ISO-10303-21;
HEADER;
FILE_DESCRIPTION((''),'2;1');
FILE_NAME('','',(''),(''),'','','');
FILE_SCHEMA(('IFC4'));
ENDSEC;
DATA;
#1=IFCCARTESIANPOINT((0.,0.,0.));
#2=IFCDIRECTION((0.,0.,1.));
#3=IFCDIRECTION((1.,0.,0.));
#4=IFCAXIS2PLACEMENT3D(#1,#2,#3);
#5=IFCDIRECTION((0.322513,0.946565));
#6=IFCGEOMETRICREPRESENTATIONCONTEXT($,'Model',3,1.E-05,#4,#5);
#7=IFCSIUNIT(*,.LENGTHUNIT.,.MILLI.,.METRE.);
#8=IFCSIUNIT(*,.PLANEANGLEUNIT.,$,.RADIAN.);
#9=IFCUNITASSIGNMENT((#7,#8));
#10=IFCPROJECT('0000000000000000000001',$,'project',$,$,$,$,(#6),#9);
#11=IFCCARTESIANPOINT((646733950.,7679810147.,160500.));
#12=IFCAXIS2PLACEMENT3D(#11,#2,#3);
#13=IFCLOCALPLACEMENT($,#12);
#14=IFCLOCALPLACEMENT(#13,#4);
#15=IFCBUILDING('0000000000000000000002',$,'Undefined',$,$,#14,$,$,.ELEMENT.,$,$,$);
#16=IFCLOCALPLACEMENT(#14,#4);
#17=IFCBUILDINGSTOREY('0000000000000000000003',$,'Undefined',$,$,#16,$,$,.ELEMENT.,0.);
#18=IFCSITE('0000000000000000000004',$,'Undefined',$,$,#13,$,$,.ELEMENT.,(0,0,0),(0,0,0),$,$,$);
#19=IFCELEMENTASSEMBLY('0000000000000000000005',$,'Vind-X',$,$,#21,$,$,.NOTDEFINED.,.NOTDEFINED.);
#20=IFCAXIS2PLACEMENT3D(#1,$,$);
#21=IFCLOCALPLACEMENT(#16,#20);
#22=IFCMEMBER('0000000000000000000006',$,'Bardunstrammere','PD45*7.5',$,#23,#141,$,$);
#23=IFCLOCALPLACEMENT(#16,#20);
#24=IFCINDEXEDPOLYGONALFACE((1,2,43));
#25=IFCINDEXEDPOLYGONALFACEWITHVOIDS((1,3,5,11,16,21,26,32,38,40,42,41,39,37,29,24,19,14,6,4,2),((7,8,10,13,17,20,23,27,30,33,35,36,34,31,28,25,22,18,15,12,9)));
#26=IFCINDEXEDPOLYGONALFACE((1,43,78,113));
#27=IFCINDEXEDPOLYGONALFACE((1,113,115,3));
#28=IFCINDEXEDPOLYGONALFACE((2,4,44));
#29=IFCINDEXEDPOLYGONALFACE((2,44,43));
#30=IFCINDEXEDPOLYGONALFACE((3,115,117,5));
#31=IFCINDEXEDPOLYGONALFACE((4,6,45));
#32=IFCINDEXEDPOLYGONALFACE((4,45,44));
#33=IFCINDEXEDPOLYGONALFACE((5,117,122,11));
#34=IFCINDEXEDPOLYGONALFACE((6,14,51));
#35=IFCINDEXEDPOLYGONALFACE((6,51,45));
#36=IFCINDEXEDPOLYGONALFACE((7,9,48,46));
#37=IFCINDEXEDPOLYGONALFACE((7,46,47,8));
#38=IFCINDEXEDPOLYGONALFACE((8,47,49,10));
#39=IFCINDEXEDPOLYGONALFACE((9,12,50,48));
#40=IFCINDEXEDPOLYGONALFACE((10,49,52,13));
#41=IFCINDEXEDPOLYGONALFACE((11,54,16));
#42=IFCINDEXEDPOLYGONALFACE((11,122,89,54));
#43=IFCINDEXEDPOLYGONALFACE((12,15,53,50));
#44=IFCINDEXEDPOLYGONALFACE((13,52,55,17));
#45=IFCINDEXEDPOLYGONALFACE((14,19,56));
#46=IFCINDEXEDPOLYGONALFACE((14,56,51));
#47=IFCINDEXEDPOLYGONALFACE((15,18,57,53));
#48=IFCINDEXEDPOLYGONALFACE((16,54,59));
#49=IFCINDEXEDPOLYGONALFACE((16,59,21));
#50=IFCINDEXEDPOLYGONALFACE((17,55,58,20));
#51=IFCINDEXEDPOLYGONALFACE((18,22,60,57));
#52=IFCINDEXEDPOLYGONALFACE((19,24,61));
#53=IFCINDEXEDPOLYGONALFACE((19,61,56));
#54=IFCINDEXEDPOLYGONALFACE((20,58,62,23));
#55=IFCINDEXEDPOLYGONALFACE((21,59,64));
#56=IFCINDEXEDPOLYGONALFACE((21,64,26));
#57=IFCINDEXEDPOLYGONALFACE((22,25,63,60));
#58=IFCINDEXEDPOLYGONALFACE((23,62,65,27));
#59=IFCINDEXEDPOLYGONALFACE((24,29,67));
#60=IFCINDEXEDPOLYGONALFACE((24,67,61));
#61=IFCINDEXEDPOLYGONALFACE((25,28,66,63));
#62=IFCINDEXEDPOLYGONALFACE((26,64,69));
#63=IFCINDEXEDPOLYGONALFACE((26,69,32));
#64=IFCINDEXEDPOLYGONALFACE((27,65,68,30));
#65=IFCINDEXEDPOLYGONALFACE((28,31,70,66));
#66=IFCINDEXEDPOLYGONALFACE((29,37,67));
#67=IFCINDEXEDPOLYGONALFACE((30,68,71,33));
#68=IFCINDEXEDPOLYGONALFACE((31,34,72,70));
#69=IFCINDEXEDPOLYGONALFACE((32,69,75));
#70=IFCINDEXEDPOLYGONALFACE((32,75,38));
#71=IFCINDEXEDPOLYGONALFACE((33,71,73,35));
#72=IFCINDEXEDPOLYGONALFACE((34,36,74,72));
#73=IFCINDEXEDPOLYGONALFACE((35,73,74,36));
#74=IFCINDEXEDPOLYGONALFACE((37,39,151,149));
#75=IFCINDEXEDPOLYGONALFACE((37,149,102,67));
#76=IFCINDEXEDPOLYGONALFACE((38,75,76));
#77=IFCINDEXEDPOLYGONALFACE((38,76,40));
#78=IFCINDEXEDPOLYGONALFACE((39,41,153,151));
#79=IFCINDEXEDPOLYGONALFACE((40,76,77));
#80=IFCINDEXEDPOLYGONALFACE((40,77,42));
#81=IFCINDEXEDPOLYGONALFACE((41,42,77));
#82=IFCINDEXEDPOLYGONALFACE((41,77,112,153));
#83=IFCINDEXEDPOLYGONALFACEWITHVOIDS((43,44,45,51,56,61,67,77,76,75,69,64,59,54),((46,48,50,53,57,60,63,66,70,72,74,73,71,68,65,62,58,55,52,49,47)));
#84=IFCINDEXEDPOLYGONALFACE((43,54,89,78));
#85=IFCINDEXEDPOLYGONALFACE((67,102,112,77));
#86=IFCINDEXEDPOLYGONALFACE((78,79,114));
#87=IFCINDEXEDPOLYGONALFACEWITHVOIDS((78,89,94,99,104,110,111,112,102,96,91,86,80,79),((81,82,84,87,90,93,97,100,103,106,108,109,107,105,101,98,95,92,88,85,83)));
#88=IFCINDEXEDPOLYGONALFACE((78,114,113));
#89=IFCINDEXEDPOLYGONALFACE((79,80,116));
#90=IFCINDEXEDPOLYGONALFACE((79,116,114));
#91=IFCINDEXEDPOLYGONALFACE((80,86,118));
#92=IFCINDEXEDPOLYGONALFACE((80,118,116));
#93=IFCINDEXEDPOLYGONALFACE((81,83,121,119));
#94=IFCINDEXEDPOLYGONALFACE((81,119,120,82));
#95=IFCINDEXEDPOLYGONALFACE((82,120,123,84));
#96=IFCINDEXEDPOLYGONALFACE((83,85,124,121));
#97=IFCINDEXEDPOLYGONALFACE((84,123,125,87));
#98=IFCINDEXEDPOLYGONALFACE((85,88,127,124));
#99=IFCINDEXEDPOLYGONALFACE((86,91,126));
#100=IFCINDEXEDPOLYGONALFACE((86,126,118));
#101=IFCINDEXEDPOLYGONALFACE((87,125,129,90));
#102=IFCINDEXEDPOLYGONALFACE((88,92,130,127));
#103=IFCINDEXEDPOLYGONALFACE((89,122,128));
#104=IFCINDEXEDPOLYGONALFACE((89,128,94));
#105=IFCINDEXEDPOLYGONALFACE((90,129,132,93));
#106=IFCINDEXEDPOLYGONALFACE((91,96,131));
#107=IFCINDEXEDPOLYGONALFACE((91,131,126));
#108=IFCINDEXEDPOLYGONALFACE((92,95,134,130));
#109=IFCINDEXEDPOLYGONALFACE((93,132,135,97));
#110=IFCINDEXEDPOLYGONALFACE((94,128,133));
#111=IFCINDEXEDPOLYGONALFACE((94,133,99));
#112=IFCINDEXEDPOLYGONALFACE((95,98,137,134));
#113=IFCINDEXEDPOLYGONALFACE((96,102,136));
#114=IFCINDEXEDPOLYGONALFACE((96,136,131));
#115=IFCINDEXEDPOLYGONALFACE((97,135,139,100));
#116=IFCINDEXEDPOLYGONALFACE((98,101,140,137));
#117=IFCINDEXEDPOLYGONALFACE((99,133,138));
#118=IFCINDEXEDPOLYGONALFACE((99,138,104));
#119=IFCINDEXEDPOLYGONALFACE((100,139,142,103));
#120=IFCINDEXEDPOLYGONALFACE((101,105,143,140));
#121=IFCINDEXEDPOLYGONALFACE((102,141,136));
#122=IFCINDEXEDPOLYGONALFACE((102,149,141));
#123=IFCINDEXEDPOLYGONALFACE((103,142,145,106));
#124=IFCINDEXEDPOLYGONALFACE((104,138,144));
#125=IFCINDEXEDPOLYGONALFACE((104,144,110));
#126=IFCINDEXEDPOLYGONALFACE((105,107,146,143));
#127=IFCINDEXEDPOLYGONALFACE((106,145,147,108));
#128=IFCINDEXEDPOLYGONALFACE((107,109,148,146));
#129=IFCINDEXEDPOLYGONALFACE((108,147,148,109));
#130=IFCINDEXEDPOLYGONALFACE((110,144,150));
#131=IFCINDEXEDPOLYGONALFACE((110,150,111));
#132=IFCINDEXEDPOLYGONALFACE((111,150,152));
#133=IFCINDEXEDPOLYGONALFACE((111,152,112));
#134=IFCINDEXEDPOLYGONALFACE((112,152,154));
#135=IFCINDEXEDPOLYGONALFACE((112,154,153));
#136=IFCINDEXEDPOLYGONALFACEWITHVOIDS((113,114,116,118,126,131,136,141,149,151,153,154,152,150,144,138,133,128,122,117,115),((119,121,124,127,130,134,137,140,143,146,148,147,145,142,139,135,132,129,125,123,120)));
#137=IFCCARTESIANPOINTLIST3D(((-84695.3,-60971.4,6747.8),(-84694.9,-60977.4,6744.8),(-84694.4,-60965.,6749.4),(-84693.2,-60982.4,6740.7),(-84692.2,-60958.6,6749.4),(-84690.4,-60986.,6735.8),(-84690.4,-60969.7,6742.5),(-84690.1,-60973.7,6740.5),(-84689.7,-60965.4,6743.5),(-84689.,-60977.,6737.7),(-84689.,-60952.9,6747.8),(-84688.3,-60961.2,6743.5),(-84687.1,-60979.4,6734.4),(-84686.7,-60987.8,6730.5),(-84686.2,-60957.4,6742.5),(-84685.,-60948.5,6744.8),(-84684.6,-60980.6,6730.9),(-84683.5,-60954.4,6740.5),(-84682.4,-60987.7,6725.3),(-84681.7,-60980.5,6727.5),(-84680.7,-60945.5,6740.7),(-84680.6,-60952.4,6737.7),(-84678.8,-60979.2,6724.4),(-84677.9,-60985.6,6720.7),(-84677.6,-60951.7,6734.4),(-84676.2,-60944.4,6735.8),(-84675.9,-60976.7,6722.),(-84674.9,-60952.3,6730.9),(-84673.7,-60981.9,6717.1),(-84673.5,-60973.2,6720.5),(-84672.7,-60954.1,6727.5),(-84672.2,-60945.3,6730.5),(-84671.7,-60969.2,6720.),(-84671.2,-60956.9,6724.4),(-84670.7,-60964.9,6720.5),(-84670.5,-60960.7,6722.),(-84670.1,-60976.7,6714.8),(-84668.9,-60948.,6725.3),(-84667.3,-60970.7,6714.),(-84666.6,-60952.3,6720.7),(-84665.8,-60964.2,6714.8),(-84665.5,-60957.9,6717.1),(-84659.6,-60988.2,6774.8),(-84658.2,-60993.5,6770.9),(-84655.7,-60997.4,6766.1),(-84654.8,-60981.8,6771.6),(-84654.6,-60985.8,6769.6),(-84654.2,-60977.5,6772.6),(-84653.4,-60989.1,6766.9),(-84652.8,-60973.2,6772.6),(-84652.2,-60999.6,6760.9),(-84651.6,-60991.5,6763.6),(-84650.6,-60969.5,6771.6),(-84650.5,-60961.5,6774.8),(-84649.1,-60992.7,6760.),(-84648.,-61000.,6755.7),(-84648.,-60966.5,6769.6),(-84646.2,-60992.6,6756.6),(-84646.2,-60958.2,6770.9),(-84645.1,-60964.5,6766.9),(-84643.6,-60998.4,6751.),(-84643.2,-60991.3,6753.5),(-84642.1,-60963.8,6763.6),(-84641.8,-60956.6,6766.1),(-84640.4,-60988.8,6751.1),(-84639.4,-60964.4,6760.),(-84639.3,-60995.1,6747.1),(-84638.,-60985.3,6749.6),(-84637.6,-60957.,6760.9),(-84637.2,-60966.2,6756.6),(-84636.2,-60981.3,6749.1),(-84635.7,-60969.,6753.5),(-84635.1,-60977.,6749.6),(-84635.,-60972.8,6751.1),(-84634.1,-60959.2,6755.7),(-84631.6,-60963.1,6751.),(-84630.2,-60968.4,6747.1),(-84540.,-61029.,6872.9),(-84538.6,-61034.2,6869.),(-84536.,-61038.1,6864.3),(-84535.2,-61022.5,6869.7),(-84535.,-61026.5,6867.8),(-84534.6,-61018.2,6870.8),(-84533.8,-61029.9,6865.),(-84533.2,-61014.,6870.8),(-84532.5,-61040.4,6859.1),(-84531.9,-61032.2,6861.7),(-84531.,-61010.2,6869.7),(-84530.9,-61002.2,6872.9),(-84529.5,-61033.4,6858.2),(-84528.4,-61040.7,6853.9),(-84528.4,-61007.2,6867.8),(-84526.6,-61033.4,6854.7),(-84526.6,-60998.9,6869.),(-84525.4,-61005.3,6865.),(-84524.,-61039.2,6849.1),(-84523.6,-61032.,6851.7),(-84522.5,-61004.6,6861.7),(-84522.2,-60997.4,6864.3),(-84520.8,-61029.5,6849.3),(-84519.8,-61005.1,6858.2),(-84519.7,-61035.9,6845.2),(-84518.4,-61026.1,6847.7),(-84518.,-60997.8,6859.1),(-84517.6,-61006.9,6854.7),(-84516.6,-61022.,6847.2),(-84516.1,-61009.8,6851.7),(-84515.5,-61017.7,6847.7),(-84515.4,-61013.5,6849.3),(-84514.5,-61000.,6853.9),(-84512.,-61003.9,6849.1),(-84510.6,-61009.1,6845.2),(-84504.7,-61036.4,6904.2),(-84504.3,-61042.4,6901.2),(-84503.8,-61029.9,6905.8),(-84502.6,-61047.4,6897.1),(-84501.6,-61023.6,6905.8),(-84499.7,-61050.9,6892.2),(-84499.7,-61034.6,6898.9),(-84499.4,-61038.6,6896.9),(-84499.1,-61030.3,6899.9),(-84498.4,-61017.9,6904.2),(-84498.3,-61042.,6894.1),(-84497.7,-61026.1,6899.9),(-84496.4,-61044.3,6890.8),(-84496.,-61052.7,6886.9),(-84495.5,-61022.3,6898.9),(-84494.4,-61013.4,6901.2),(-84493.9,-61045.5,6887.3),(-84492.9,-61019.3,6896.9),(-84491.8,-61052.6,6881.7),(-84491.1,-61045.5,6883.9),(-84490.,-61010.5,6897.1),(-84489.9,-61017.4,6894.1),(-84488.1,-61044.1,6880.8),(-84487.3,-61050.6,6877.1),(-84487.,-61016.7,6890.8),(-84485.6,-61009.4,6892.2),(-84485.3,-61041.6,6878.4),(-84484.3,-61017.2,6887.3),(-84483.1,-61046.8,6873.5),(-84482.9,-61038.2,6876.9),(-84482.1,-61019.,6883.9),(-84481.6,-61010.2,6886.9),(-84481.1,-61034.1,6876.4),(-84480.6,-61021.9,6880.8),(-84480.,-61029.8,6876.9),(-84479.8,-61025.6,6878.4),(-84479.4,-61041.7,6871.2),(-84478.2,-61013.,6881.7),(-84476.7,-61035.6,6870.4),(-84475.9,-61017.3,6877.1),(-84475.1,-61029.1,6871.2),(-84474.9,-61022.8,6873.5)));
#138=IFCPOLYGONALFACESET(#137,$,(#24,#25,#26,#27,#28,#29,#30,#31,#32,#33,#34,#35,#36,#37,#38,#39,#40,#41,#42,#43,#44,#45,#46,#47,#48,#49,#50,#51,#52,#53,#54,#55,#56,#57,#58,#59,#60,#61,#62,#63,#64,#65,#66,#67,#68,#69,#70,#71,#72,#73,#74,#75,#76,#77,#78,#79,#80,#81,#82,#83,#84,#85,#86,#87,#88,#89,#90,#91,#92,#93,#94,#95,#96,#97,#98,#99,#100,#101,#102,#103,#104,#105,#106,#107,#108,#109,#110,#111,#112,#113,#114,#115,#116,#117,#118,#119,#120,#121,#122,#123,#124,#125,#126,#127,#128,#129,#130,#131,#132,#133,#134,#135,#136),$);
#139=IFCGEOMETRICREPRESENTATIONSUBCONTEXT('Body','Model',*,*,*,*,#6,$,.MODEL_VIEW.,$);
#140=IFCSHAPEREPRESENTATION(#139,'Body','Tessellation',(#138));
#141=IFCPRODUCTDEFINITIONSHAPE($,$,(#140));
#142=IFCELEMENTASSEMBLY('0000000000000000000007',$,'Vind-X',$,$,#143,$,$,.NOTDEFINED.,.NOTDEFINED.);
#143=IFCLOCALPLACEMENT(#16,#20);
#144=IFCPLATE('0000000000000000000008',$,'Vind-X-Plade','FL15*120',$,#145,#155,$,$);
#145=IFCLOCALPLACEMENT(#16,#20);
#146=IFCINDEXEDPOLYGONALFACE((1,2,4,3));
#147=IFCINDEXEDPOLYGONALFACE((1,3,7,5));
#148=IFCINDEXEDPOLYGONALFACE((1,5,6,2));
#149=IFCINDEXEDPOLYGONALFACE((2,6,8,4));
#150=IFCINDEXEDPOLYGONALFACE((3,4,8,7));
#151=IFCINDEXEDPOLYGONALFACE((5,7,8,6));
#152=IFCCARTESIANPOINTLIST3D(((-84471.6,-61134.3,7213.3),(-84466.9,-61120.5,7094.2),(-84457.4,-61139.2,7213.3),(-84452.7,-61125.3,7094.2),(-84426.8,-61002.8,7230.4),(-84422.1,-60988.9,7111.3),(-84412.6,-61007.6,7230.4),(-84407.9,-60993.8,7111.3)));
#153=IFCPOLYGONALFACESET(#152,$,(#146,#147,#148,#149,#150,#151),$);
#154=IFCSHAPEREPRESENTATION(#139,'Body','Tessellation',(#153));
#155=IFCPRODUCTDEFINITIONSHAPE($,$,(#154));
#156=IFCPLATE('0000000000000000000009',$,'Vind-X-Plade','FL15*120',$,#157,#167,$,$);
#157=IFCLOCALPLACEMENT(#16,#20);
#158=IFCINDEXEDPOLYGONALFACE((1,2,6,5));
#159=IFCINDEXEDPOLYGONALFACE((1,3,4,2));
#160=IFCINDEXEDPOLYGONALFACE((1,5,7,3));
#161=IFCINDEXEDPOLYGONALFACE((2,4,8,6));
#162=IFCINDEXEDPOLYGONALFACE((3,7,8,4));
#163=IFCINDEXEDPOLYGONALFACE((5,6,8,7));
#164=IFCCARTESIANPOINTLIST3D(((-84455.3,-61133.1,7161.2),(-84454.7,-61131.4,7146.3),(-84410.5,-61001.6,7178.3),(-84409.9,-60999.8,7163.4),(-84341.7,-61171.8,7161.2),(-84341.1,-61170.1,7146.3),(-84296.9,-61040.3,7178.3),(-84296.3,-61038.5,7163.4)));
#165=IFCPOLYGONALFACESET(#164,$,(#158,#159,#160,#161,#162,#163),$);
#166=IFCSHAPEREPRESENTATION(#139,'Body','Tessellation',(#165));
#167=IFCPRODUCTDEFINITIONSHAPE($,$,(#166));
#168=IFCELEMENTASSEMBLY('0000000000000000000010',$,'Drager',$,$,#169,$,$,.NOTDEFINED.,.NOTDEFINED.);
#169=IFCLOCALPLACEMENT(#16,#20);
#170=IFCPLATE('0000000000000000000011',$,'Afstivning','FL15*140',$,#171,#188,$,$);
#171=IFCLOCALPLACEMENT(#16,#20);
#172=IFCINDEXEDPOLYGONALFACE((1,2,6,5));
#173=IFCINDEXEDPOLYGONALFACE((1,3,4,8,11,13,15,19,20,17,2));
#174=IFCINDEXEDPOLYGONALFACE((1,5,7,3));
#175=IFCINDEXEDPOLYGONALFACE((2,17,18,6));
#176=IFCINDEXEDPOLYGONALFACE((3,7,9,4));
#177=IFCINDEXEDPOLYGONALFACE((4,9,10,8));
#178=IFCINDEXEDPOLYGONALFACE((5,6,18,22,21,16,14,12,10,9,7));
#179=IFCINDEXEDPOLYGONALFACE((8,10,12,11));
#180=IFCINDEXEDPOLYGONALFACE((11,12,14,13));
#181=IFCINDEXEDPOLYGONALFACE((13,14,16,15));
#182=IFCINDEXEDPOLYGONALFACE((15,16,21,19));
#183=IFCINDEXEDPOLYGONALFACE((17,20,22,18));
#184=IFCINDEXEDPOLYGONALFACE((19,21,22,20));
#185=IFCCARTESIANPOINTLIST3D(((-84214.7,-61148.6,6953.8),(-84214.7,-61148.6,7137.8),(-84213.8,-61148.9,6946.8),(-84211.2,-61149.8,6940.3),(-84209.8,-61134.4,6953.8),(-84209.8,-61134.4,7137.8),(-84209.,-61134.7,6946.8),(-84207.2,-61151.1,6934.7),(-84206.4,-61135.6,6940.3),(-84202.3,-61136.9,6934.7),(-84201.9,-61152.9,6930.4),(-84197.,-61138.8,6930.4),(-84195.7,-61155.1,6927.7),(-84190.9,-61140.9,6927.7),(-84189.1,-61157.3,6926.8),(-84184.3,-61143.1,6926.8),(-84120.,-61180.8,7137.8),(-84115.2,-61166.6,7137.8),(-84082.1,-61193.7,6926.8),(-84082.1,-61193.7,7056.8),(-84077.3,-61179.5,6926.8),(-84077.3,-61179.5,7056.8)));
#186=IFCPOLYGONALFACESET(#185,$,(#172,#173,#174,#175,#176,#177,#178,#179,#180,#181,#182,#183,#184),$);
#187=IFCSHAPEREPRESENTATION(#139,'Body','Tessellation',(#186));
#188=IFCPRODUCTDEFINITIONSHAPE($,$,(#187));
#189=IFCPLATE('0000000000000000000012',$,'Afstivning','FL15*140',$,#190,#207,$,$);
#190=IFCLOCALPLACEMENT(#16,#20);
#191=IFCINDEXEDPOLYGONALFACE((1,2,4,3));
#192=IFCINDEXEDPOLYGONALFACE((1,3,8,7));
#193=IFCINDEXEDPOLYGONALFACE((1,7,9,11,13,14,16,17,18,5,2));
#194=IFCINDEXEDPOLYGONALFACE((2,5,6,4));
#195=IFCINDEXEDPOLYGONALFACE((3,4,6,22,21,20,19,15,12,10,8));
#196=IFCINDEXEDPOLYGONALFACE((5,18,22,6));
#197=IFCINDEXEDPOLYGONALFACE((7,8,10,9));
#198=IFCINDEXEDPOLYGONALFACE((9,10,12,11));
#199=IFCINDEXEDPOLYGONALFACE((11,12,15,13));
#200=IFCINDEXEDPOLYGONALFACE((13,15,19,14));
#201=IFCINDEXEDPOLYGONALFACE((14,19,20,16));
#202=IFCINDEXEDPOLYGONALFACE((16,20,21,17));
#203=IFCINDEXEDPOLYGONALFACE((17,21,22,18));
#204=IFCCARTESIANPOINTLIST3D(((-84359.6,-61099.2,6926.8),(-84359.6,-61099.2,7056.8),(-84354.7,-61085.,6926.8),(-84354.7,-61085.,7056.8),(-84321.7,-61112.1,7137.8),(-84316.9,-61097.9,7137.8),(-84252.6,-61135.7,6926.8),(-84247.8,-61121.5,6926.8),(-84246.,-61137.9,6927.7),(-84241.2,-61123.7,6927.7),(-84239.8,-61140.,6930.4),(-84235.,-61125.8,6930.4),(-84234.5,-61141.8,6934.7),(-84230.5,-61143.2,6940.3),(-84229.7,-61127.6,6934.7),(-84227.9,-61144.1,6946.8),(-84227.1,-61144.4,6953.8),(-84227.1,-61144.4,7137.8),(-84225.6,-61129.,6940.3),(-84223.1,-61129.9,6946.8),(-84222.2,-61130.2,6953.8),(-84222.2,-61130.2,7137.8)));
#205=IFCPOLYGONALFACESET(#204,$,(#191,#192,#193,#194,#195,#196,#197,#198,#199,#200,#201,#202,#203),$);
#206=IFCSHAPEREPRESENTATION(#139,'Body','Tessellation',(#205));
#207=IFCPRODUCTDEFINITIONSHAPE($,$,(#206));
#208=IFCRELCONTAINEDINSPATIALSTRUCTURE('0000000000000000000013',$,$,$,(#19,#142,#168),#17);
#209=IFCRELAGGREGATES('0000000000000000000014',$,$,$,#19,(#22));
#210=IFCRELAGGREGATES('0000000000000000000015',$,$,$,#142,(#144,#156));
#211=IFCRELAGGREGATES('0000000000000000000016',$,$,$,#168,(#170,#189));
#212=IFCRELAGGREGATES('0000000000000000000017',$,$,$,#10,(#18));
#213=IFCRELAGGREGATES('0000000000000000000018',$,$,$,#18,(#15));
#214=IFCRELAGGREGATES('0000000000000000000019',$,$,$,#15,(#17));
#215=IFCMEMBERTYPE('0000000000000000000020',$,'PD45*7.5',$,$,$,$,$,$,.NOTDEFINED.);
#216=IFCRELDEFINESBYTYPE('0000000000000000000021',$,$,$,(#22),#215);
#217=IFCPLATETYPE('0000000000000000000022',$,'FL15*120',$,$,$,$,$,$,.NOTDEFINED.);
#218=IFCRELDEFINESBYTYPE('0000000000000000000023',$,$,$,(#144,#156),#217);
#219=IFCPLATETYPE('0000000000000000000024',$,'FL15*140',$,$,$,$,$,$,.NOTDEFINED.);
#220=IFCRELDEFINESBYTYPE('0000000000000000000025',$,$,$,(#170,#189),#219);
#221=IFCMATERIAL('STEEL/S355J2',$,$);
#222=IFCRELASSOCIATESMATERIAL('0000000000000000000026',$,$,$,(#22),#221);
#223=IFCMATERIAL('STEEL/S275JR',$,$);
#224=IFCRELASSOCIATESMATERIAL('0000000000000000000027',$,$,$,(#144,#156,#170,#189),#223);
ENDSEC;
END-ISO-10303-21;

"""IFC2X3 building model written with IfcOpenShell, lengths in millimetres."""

from ifc_helpers import new_model, si_unit, direction, frame, frame_2d, origin_with_axes, origin_2d_with_axis, place, context, subcontext, project, spatial, polyline, circle_curve, parameter, trimmed, segment, composite_curve, rectangle, hollow_circle, outline, extrude, boolean, material, type_object, element, aggregate, save


model = new_model("IFC2X3")

# Units and contexts
model_context = context("Model", 3, precision=1e-05, world=origin_with_axes(), true_north=direction((0.322513, 0.946565)))
body_context = subcontext(model_context, "Body", "Model", "MODEL_VIEW")
ifc_project = project(units=[si_unit("LENGTHUNIT", "METRE", prefix="MILLI"), si_unit("PLANEANGLEUNIT", "RADIAN")], contexts=[model_context])

# Site, building, storey
site_placement = place(None, frame((646733950.0, 7679810147.0, 160500.0), z_axis=(0.0, 0.0, 1.0), x_axis=(1.0, 0.0, 0.0)))
site = spatial("IfcSite", under=ifc_project, at=site_placement, Name="Undefined", CompositionType="ELEMENT", RefLatitude=(0, 0, 0), RefLongitude=(0, 0, 0))
building_placement = place(site_placement, origin_with_axes())
building = spatial("IfcBuilding", under=site, at=building_placement, Name="Undefined", CompositionType="ELEMENT")
storey_placement = place(building_placement, origin_with_axes())
storey = spatial("IfcBuildingStorey", under=building, at=storey_placement, Name="Undefined", CompositionType="ELEMENT", Elevation=0.0)

# Shared definitions
ifc_material_1 = material(Name="STEEL/S355J2")

# Element assembly
assembly_1_placement = place(storey_placement, origin_with_axes())
assembly_1 = element("IfcElementAssembly", 1, at=assembly_1_placement, inside=storey, Name="Vind-X", AssemblyPlace="NOTDEFINED", PredefinedType="NOTDEFINED")

# Member
member_type_1 = type_object("IfcMemberType", Name="PD45*7.5", PredefinedType="NOTDEFINED")
member_1_placement = place(assembly_1_placement, frame((-84489.8, -61031.2, 6888.2), z_axis=(0.322513, 0.946565, 0.0), x_axis=(-0.747608, 0.254725, -0.613349)))
member_1 = element("IfcMember", 2, at=member_1_placement, type_object=member_type_1, material=ifc_material_1, Name="Bardunstrammere", Description="PD45*7.5", context=body_context, shape_type="CSG", body=[
    boolean("DIFFERENCE", extrude(hollow_circle(Radius=22.5, WallThickness=7.5, at=origin_2d_with_axis()), frame((255.0, 0.0, 0.0), z_axis=(-1.0, 0.0, 0.0), x_axis=(0.0, -1.0, 0.0)), (0.0, 0.0, 1.0), 255.0), extrude(rectangle(XDim=35.0, YDim=90.0, at=origin_2d_with_axis()), frame((207.5, 0.0, 0.0), z_axis=(-1.0, 0.0, 0.0), x_axis=(0.0, -1.0, 0.0)), (0.0, 0.0, 1.0), 160.0)),
])

# Element assemblies, plates
assembly_2_placement = place(storey_placement, origin_with_axes())
assembly_2 = element("IfcElementAssembly", 3, at=assembly_2_placement, inside=storey, Name="Vind-X", AssemblyPlace="NOTDEFINED", PredefinedType="NOTDEFINED")
ifc_material_2 = material(Name="STEEL/S275JR")
plate_type_1 = type_object("IfcPlateType", Name="FL15*120", PredefinedType="NOTDEFINED")
plate_1_placement = place(assembly_2_placement, frame((-84459.8, -61122.9, 7094.2), z_axis=(0.946565, -0.322513, 0.0), x_axis=(0.320109, 0.93951, 0.121869)))
plate_1 = element("IfcPlate", 4, at=plate_1_placement, type_object=plate_type_1, material=ifc_material_2, Name="Vind-X-Plade", Description="FL15*120", context=body_context, shape_type="SweptSolid", body=[
    extrude(outline(polyline([(0.0, 0.0), (140.0, 0.0), (140.0, 120.0), (0.0, 120.0), (0.0, 0.0)])), frame((0.0, 0.0, -7.5), z_axis=(0.0, 0.0, 1.0), x_axis=(1.0, 0.0, 0.0)), (0.0, 0.0, 1.0), 15.0),
])
plate_2_placement = place(assembly_2_placement, frame((-84319.0, -61105.2, 7162.3), z_axis=(0.039304, 0.115357, -0.992546), x_axis=(-0.946565, 0.322513, 0.0)))
plate_2 = element("IfcPlate", 5, at=plate_2_placement, type_object=plate_type_1, material=ifc_material_2, Name="Vind-X-Plade", Description="FL15*120", context=body_context, shape_type="SweptSolid", body=[
    extrude(outline(polyline([(0.0, -70.0), (0.0, 70.0), (120.0, 70.0), (120.0, -70.0), (0.0, -70.0)])), frame((0.0, 0.0, -7.5), z_axis=(0.0, 0.0, 1.0), x_axis=(1.0, 0.0, 0.0)), (0.0, 0.0, 1.0), 15.0),
])
assembly_3_placement = place(storey_placement, origin_with_axes())
assembly_3 = element("IfcElementAssembly", 6, at=assembly_3_placement, inside=storey, Name="Drager", AssemblyPlace="NOTDEFINED", PredefinedType="NOTDEFINED")
plate_type_2 = type_object("IfcPlateType", Name="FL15*140", PredefinedType="NOTDEFINED")
plate_3_placement = place(assembly_3_placement, frame((-84212.2, -61141.5, 6926.8), z_axis=(-0.322513, -0.946565, 0.0), x_axis=(0.946565, -0.322513, 0.0)))
plate_3 = element("IfcPlate", 7, at=plate_3_placement, type_object=plate_type_2, material=ifc_material_2, Name="Afstivning", Description="FL15*140", context=body_context, shape_type="SweptSolid", body=[
    extrude(outline(composite_curve([segment(trimmed(circle_curve(frame_2d((27.0, 27.0), x_axis=(-1.0, 0.0)), 27.0), [parameter(0.0)], [parameter(1.570796)], True, "PARAMETER"), True, "CONTINUOUS"), segment(polyline([(27.0, 0.0), (140.0, 0.0), (140.0, 130.0), (100.0, 211.0), (0.0, 211.0), (0.0, 27.0)]), True, "CONTINUOUS")], self_intersect=True)), frame((0.0, 0.0, -7.5), z_axis=(0.0, 0.0, 1.0), x_axis=(1.0, 0.0, 0.0)), (0.0, 0.0, 1.0), 15.0),
])
plate_4_placement = place(assembly_3_placement, frame((-84357.2, -61092.1, 6926.8), z_axis=(-0.322513, -0.946565, 0.0), x_axis=(0.946565, -0.322513, 0.0)))
plate_4 = element("IfcPlate", 8, at=plate_4_placement, type_object=plate_type_2, material=ifc_material_2, Name="Afstivning", Description="FL15*140", context=body_context, shape_type="SweptSolid", body=[
    extrude(outline(composite_curve([segment(polyline([(0.0, 0.0), (113.0, 0.0)]), True, "CONTINUOUS"), segment(trimmed(circle_curve(frame_2d((113.0, 27.0), x_axis=(0.0, -1.0)), 27.0), [parameter(0.0)], [parameter(1.570796)], True, "PARAMETER"), True, "CONTINUOUS"), segment(polyline([(140.0, 27.0), (140.0, 211.0), (40.0, 211.0), (0.0, 130.0), (0.0, 0.0)]), True, "CONTINUOUS")], self_intersect=True)), frame((0.0, 0.0, -7.5), z_axis=(0.0, 0.0, 1.0), x_axis=(1.0, 0.0, 0.0)), (0.0, 0.0, 1.0), 15.0),
])

aggregate(assembly_1, [member_1])
aggregate(assembly_2, [plate_1, plate_2])
aggregate(assembly_3, [plate_3, plate_4])

save(model, "model.ifc")
